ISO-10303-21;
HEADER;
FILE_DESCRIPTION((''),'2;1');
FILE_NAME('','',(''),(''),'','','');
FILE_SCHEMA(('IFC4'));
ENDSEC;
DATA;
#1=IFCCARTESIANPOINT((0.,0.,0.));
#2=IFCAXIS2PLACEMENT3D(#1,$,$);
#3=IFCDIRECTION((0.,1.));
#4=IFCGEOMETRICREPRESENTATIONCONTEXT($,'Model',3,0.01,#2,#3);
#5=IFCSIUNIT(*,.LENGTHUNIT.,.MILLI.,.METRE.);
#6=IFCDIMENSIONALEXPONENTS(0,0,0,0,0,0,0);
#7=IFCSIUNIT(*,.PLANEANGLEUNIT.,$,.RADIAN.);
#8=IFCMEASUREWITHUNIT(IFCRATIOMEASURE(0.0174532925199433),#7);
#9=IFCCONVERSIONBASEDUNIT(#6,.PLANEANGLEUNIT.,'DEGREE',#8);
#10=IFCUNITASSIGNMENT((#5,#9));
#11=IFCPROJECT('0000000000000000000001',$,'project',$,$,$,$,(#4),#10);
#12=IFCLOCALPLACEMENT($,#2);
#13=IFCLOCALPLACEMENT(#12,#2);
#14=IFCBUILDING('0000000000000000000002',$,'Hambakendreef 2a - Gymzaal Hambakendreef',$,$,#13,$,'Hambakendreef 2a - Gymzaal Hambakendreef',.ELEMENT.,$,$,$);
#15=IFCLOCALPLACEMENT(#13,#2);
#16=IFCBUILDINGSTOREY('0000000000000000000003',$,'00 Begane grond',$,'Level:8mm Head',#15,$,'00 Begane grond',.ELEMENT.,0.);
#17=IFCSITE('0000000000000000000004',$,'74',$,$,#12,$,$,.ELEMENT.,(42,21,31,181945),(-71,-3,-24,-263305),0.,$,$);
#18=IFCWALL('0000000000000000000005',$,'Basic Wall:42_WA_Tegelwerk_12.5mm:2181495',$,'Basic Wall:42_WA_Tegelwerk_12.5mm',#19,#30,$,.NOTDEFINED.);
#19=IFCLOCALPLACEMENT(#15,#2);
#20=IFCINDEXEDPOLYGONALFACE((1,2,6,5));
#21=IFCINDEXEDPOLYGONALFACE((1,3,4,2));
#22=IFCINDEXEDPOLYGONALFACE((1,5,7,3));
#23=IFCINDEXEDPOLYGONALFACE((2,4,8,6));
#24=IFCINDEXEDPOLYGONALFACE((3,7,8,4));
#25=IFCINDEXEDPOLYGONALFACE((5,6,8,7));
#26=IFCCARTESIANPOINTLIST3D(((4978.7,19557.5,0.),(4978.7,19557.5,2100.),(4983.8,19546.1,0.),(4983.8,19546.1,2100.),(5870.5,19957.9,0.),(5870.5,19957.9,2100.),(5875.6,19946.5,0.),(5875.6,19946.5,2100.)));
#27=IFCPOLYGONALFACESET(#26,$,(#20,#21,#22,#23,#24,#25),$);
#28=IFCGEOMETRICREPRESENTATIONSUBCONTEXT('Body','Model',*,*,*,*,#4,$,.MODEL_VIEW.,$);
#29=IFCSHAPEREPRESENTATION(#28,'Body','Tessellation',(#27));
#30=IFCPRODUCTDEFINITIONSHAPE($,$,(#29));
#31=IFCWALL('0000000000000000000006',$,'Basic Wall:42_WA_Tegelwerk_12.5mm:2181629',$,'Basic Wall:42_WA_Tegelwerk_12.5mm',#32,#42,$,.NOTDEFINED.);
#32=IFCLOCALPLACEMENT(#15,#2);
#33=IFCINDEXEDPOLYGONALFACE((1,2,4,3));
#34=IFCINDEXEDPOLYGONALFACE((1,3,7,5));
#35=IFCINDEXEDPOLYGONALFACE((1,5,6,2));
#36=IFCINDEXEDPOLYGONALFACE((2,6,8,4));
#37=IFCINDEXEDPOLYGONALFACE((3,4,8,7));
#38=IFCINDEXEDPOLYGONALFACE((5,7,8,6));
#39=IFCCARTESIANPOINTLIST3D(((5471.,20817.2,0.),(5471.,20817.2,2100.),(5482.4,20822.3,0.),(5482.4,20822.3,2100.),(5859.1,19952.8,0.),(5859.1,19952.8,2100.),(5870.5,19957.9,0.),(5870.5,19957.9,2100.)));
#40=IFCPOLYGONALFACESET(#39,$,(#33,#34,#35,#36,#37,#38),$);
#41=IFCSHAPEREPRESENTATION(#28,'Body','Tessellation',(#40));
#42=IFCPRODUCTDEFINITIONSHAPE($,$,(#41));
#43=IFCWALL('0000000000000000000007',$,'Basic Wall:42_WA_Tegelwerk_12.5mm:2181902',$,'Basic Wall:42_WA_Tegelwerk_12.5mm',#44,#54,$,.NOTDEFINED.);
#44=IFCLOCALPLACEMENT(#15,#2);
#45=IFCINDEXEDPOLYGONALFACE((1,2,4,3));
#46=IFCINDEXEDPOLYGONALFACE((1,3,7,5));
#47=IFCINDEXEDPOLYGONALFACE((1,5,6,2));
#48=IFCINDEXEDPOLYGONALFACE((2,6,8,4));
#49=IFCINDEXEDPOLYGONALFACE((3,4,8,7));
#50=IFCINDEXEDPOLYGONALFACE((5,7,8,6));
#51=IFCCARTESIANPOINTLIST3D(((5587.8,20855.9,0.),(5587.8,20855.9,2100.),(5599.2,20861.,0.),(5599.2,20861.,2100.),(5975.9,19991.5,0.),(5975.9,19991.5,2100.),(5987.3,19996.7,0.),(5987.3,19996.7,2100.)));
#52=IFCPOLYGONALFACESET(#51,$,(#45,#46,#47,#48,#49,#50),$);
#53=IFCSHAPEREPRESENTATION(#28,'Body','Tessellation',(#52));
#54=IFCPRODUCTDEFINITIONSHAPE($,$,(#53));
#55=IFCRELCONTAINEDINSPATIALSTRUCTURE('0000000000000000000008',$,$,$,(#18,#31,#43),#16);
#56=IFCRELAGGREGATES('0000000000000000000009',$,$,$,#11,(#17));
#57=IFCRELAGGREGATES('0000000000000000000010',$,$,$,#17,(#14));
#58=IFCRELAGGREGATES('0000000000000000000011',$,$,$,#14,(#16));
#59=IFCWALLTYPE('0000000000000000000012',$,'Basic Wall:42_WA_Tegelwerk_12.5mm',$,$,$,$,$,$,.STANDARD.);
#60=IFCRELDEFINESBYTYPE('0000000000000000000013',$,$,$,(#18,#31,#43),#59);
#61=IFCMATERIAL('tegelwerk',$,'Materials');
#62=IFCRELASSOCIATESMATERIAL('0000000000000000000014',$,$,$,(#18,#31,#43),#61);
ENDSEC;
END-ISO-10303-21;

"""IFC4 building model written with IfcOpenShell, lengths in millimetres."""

from ifc_helpers import new_model, entity, si_unit, converted_unit, direction, frame, origin, place, context, subcontext, project, spatial, indexed_curve, outline, extrude, material, type_object, element, save


model = new_model("IFC4")

# Units and contexts
model_context = context("Model", 3, precision=0.01, world=origin(), true_north=direction((0.0, 1.0)))
body_context = subcontext(model_context, "Body", "Model", "MODEL_VIEW")
ifc_project = project(units=[si_unit("LENGTHUNIT", "METRE", prefix="MILLI"), converted_unit("PLANEANGLEUNIT", "DEGREE", entity("IfcRatioMeasure", 0.0174532925199433), si_unit("PLANEANGLEUNIT", "RADIAN"), dimensions=[0, 0, 0, 0, 0, 0, 0])], contexts=[model_context])

# Site, building, storey
site_placement = place(None, origin())
site = spatial("IfcSite", under=ifc_project, at=site_placement, Name="74", CompositionType="ELEMENT", RefLatitude=(42, 21, 31, 181945), RefLongitude=(-71, -3, -24, -263305), RefElevation=0.0)
building_placement = place(site_placement, origin())
building = spatial("IfcBuilding", under=site, at=building_placement, Name="Hambakendreef 2a - Gymzaal Hambakendreef", LongName="Hambakendreef 2a - Gymzaal Hambakendreef", CompositionType="ELEMENT")
storey_placement = place(building_placement, origin())
storey = spatial("IfcBuildingStorey", under=building, at=storey_placement, Name="00 Begane grond", ObjectType="Level:8mm Head", LongName="00 Begane grond", CompositionType="ELEMENT", Elevation=0.0)

# Walls
ifc_material_1 = material(Name="tegelwerk", Category="Materials")
wall_type_1 = type_object("IfcWallType", Name="Basic Wall:42_WA_Tegelwerk_12.5mm", PredefinedType="STANDARD")
wall_1_placement = place(storey_placement, frame((5873.0, 19952.2, 0.0), z_axis=(0.0, 0.0, 1.0), x_axis=(-0.91227, -0.40959, 0.0)))
element("IfcWall", 1, at=wall_1_placement, inside=storey, type_object=wall_type_1, material=ifc_material_1, Name="Basic Wall:42_WA_Tegelwerk_12.5mm:2181495", ObjectType="Basic Wall:42_WA_Tegelwerk_12.5mm", PredefinedType="NOTDEFINED", context=body_context, shape_type="SweptSolid", body=[
    extrude(outline(indexed_curve([(977.5, 6.2), (0.0, 6.3), (0.0, -6.3), (977.5, -6.3), (977.5, 6.2)], self_intersect=False)), origin(), (0.0, 0.0, 1.0), 2100.0),
])
wall_2_placement = place(storey_placement, frame((5864.8, 19955.3, 0.0), z_axis=(0.0, 0.0, 1.0), x_axis=(-0.40959, 0.91227, 0.0)))
element("IfcWall", 2, at=wall_2_placement, inside=storey, type_object=wall_type_1, material=ifc_material_1, Name="Basic Wall:42_WA_Tegelwerk_12.5mm:2181629", ObjectType="Basic Wall:42_WA_Tegelwerk_12.5mm", PredefinedType="NOTDEFINED", context=body_context, shape_type="SweptSolid", body=[
    extrude(outline(indexed_curve([(947.5, 6.2), (0.0, 6.2), (0.0, -6.2), (947.5, -6.2), (947.5, 6.2)], self_intersect=False)), origin(), (0.0, 0.0, 1.0), 2100.0),
])
wall_3_placement = place(storey_placement, frame((5981.6, 19994.1, 0.0), z_axis=(0.0, 0.0, 1.0), x_axis=(-0.40959, 0.91227, 0.0)))
element("IfcWall", 3, at=wall_3_placement, inside=storey, type_object=wall_type_1, material=ifc_material_1, Name="Basic Wall:42_WA_Tegelwerk_12.5mm:2181902", ObjectType="Basic Wall:42_WA_Tegelwerk_12.5mm", PredefinedType="NOTDEFINED", context=body_context, shape_type="SweptSolid", body=[
    extrude(outline(indexed_curve([(947.5, 6.3), (0.0, 6.2), (0.0, -6.2), (947.5, -6.2), (947.5, 6.3)], self_intersect=False)), origin(), (0.0, 0.0, 1.0), 2100.0),
])

save(model, "model.ifc")
